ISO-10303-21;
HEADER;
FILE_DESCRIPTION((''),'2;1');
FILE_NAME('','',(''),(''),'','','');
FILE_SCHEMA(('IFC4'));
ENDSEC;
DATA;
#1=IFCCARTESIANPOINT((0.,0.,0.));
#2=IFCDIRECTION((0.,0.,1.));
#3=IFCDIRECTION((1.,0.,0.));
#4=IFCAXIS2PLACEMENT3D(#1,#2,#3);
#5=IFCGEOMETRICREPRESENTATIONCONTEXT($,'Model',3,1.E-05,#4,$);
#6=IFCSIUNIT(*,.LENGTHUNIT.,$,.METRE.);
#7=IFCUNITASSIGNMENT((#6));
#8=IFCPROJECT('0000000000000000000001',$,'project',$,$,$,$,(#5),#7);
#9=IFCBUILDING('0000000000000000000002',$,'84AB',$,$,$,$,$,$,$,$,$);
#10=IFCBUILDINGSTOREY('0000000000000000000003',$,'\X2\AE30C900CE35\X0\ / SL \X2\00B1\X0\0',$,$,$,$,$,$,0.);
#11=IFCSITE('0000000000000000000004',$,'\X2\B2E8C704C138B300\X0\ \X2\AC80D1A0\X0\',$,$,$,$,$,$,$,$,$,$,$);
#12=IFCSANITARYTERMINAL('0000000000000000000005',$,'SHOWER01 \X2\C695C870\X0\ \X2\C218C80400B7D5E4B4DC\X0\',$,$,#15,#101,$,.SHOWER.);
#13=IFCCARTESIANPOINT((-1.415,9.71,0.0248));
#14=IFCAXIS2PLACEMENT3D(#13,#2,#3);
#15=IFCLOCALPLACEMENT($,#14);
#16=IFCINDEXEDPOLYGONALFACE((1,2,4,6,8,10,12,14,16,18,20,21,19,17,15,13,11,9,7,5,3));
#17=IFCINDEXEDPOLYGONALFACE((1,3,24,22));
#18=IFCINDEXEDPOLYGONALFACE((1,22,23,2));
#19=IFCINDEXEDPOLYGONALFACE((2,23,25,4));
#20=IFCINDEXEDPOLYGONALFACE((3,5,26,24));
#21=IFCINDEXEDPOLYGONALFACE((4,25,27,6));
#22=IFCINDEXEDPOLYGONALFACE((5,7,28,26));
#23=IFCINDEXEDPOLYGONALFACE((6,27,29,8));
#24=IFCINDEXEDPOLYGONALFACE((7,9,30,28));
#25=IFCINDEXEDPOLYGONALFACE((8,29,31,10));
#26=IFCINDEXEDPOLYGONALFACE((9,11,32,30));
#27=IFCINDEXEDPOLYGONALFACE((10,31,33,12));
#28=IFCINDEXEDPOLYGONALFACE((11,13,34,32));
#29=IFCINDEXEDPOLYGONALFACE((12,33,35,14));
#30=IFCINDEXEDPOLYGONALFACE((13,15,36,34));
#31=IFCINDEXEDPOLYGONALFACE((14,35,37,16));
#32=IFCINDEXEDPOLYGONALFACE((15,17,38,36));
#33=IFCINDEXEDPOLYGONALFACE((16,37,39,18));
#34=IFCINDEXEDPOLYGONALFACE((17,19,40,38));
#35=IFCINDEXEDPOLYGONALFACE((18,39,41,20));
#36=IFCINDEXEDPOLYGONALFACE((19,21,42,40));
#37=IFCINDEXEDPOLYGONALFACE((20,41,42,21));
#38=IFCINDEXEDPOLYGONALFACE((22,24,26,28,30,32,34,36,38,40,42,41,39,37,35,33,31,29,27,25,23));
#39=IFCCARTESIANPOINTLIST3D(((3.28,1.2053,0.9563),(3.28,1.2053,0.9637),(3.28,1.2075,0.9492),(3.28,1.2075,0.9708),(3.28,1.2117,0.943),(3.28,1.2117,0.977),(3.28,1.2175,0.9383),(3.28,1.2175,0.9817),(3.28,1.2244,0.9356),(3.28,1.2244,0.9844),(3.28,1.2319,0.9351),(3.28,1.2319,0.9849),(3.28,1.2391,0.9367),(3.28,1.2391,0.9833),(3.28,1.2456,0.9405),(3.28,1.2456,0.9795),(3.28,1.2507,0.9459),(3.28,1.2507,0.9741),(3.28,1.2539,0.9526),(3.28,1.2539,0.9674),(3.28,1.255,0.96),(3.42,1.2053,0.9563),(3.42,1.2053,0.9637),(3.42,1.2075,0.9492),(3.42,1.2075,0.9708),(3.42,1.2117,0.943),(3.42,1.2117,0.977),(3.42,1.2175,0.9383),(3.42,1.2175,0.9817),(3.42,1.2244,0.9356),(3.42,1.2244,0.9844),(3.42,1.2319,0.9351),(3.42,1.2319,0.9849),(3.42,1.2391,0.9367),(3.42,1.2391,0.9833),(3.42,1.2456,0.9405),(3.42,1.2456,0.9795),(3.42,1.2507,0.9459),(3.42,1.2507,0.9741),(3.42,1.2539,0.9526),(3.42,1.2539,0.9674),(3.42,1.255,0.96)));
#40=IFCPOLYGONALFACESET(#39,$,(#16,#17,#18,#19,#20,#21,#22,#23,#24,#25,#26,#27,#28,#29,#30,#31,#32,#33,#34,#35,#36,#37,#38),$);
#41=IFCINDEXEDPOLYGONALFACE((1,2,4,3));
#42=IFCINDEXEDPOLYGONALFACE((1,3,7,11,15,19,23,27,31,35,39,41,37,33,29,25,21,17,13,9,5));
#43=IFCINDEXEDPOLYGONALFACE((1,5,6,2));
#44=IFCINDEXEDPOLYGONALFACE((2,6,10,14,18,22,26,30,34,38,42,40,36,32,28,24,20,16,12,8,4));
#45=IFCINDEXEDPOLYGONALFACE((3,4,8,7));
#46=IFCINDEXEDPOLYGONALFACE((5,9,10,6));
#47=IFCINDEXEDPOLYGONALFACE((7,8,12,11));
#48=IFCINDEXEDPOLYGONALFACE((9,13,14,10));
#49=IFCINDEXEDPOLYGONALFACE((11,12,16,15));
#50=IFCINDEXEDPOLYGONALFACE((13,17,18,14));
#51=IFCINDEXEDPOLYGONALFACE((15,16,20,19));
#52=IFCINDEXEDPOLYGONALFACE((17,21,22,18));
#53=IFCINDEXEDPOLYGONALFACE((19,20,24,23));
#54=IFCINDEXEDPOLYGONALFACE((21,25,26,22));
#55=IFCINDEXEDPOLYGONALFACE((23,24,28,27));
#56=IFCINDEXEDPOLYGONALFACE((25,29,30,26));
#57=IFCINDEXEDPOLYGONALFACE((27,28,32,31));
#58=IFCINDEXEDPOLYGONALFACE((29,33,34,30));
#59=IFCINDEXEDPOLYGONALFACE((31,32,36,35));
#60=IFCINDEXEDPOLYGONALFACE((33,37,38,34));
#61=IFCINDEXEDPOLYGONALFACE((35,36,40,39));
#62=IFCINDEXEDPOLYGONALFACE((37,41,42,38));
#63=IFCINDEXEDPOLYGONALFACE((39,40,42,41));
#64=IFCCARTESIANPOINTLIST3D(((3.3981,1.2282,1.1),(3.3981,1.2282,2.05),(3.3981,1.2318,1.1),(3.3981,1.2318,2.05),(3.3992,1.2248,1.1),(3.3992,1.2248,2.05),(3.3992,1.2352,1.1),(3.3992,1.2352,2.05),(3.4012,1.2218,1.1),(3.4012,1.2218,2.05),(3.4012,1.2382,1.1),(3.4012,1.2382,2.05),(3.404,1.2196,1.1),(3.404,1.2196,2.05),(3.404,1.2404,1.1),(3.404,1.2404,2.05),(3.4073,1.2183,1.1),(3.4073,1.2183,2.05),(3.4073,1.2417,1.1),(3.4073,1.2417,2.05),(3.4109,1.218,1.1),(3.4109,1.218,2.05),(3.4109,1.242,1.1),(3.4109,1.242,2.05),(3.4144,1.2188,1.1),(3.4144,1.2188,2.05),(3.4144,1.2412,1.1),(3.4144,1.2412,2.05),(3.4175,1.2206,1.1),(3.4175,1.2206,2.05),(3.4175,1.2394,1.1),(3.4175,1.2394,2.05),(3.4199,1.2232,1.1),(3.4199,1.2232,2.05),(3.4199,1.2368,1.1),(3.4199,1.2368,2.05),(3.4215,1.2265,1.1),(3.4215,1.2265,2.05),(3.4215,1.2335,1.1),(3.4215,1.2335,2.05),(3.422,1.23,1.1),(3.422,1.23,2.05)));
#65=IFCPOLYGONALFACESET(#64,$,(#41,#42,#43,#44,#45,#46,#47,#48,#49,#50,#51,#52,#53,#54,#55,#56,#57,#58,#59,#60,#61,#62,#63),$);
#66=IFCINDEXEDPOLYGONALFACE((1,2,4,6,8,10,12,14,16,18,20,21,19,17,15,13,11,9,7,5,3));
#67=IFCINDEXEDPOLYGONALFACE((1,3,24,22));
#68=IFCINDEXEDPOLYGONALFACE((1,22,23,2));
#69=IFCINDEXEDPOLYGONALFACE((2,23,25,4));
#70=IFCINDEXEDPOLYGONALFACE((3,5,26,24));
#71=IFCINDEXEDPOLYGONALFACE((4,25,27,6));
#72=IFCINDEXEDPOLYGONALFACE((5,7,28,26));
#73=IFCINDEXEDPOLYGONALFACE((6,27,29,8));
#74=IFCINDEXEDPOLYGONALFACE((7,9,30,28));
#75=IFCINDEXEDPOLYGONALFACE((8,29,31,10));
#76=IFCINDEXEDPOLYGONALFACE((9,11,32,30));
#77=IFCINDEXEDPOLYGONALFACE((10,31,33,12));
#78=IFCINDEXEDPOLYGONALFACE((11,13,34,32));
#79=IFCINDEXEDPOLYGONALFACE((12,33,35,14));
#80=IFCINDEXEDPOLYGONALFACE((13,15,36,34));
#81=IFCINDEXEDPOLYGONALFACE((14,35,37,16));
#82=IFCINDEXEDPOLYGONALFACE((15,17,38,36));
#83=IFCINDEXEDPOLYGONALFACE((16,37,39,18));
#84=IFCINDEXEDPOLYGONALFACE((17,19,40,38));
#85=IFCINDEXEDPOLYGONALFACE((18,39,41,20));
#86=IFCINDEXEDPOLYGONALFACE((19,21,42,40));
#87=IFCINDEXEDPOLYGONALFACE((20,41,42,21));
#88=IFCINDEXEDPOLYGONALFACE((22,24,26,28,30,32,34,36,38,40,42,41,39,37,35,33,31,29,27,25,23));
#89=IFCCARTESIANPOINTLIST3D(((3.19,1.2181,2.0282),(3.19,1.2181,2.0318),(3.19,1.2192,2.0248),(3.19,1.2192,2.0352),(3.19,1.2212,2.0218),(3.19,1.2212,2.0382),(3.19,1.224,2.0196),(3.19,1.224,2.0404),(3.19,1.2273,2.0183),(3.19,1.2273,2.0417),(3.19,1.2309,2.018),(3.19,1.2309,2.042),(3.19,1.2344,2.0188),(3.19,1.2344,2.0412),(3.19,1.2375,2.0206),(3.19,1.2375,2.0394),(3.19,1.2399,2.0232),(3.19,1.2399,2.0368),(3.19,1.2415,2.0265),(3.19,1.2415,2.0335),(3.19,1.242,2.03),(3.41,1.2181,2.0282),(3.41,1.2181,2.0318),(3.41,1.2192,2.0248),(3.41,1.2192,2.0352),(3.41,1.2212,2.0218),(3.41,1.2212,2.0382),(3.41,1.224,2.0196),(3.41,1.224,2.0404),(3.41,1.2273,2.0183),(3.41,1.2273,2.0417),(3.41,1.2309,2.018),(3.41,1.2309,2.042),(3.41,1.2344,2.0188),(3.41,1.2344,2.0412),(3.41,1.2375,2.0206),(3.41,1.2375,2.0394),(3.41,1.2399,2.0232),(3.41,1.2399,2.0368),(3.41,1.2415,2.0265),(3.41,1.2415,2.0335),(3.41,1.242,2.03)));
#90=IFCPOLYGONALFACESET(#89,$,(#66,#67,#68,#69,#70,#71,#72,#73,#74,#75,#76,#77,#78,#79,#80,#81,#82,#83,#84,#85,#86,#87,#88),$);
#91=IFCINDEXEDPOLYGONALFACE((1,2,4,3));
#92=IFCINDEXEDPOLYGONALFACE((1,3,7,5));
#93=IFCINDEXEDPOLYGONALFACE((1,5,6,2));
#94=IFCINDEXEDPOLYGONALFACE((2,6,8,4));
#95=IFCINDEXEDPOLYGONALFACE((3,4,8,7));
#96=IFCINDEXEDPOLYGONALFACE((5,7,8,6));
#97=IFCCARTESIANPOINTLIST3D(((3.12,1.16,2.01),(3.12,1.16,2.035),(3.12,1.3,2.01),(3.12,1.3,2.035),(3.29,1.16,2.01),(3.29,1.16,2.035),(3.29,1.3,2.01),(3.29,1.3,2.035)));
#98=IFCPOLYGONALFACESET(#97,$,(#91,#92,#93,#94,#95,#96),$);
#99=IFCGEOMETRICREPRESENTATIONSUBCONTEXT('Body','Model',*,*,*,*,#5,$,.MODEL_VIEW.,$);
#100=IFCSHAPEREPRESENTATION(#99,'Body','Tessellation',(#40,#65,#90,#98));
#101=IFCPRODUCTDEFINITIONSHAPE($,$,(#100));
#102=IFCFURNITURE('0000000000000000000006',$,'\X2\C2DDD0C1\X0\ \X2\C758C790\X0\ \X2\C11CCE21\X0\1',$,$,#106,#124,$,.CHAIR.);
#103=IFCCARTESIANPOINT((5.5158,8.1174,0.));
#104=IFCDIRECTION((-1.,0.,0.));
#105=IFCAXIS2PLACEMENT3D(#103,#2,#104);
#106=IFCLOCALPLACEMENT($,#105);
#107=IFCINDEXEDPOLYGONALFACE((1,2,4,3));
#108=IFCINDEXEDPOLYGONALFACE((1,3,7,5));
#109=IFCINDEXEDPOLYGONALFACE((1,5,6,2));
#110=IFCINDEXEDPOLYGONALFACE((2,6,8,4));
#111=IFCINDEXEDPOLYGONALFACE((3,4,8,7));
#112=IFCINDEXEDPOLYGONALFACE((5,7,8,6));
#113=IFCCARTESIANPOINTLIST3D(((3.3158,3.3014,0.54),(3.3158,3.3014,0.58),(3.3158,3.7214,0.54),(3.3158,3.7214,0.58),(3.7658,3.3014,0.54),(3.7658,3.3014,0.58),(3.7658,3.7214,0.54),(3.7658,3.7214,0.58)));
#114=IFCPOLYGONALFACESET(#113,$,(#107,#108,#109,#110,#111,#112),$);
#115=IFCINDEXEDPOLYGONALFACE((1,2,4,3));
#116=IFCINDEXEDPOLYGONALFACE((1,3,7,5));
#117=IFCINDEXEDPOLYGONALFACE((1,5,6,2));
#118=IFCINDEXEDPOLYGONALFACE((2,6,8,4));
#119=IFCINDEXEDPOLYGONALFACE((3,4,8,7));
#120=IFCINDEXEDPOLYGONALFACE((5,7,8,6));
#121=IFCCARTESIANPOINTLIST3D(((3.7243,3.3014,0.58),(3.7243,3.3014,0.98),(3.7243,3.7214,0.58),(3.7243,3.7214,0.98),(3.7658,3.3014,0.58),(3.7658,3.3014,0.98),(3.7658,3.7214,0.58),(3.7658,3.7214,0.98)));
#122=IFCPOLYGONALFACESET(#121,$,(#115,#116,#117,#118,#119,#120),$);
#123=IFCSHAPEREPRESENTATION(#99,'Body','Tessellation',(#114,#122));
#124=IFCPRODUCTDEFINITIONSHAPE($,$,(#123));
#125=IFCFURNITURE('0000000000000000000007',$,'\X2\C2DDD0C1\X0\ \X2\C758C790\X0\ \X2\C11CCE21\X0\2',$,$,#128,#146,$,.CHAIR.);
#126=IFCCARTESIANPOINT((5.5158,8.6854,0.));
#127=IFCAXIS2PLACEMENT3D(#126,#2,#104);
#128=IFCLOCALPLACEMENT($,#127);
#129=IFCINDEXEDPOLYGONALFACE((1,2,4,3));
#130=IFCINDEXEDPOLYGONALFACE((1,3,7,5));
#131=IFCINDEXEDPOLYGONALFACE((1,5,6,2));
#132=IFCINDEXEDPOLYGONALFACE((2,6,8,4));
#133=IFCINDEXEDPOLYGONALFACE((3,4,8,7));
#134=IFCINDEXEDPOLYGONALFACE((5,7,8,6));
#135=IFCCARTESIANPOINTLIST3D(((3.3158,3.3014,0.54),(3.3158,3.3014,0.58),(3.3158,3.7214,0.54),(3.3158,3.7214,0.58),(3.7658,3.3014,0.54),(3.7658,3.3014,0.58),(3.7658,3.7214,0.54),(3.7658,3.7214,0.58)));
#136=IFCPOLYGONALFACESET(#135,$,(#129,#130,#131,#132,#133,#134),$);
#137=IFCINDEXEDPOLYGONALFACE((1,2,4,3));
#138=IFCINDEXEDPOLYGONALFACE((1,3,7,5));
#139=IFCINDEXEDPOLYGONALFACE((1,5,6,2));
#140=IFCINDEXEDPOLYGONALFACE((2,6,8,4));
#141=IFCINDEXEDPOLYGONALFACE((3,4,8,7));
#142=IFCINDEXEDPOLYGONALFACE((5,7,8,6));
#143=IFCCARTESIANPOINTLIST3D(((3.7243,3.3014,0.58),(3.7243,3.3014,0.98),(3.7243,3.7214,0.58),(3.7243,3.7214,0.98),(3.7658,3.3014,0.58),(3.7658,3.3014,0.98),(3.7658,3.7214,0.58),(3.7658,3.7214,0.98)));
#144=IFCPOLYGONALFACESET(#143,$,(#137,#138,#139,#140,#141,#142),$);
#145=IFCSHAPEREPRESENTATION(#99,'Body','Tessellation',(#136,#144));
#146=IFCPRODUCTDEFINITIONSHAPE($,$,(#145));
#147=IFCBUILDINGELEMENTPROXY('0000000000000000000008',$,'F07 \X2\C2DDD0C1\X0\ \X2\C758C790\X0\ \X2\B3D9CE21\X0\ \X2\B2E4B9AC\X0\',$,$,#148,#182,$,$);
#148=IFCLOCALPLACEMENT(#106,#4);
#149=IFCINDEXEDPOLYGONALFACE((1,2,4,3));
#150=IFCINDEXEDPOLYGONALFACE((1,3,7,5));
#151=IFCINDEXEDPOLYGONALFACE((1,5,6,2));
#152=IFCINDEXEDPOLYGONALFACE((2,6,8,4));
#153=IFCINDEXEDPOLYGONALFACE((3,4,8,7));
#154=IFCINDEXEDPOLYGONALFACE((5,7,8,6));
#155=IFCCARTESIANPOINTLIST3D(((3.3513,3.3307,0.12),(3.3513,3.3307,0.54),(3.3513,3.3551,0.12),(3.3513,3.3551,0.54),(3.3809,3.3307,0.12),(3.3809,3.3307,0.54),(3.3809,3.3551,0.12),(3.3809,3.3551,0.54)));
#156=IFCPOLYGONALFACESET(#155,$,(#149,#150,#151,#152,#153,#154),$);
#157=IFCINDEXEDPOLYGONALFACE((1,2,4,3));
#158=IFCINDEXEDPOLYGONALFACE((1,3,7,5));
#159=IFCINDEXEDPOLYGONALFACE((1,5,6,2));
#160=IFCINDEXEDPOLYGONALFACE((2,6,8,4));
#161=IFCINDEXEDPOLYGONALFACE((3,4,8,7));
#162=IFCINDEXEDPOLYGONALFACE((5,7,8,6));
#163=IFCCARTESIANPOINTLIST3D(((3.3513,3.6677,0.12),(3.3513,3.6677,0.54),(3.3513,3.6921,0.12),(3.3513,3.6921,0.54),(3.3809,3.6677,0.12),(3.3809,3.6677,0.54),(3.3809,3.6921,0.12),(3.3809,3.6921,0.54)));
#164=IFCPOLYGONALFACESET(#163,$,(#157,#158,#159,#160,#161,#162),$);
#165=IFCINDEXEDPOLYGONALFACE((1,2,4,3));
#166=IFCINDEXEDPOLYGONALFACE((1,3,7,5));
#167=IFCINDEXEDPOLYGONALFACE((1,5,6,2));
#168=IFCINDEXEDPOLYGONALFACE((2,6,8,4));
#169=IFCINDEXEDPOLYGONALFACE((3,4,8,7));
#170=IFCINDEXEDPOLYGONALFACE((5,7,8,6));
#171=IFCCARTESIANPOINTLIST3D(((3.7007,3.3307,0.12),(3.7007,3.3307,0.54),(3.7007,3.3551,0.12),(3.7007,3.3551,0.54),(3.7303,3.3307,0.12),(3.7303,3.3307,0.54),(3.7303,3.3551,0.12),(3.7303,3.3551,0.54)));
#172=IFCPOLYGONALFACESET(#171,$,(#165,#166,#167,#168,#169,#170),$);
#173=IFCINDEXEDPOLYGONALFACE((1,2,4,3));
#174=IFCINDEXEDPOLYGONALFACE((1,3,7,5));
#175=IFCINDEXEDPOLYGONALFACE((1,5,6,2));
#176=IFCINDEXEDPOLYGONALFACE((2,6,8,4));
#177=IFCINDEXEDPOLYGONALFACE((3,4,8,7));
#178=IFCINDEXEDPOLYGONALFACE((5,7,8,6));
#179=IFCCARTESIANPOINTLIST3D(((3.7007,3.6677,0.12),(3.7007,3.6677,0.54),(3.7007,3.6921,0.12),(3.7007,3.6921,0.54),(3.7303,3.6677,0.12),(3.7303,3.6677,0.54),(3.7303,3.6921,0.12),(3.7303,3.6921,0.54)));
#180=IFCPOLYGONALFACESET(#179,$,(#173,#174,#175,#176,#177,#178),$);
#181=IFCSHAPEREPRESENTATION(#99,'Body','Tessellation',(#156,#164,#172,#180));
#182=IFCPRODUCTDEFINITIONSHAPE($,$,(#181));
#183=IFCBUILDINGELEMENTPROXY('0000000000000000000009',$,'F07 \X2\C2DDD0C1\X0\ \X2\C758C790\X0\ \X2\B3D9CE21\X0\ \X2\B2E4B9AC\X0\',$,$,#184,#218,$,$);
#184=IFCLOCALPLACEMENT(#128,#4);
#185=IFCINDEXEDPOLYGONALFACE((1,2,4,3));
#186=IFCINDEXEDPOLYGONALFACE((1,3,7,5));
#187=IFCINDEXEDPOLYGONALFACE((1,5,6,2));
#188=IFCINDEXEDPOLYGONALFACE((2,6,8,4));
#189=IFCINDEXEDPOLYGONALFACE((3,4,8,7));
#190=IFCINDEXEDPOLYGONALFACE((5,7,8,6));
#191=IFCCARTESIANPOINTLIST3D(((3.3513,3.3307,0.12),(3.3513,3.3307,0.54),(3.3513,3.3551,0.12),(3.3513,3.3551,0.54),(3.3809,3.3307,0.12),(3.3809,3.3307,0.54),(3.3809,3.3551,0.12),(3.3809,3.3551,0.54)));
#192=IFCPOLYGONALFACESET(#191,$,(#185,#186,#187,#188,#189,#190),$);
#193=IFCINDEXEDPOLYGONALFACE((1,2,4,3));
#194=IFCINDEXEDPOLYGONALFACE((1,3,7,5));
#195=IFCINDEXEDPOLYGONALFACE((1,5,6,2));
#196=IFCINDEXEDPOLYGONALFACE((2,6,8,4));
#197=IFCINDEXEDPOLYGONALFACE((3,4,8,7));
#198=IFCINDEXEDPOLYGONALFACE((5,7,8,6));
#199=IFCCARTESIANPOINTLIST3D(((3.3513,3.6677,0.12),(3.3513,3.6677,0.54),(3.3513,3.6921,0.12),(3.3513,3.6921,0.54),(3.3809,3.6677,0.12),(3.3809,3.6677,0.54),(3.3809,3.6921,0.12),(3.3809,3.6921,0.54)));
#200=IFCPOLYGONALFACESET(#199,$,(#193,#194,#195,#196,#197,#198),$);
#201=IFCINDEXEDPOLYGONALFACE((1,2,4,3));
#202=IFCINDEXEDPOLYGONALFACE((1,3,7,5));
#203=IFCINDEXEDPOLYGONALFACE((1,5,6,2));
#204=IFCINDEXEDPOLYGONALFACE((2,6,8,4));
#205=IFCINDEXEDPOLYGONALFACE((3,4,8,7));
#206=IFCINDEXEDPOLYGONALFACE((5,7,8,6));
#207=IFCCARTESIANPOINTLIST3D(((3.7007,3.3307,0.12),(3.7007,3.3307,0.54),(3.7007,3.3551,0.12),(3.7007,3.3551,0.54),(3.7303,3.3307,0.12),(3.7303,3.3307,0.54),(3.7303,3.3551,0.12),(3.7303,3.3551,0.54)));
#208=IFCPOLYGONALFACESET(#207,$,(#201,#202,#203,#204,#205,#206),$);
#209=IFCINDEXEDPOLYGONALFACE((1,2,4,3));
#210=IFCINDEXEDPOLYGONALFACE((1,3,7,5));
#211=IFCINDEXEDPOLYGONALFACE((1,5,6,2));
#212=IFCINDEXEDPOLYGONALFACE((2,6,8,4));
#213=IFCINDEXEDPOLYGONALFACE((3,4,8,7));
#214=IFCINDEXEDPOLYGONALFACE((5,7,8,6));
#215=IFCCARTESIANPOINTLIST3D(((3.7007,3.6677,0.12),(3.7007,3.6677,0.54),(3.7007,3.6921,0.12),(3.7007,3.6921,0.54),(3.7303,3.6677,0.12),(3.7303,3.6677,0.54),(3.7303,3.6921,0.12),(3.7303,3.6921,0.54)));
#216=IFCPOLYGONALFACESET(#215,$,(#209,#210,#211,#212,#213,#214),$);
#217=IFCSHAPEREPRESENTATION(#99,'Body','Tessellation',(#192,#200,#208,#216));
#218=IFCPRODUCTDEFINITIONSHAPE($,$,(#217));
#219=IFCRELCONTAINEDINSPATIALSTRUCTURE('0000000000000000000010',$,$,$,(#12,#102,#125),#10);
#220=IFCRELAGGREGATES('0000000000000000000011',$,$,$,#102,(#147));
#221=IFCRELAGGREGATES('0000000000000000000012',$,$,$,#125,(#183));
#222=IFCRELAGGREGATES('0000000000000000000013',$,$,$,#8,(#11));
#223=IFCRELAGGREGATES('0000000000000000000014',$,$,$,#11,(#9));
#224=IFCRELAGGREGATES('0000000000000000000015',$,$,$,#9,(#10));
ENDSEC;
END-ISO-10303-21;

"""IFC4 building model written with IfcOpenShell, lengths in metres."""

from ifc_helpers import new_model, si_unit, frame, origin_with_axes, place, context, subcontext, project, spatial, polyline, circle, outline, extrude, element, aggregate, save


model = new_model("IFC4")

# Units and contexts
model_context = context("Model", 3, precision=1e-05, world=origin_with_axes())
body_context = subcontext(model_context, "Body", "Model", "MODEL_VIEW")
ifc_project = project(units=[si_unit("LENGTHUNIT", "METRE")], contexts=[model_context])

# Site, building, storey
site = spatial("IfcSite", under=ifc_project, Name="단위세대 검토")
building = spatial("IfcBuilding", under=site, Name="84AB")
storey = spatial("IfcBuildingStorey", under=building, Name="기준층 / SL ±0", Elevation=0.0)

# Sanitary terminal
sanitary_terminal_1_placement = place(None, frame((-1.415, 9.71, 0.0248), z_axis=(0.0, 0.0, 1.0), x_axis=(1.0, 0.0, 0.0)))
element("IfcSanitaryTerminal", 1, at=sanitary_terminal_1_placement, inside=storey, Name="SHOWER01 욕조 수전·헤드", PredefinedType="SHOWER", context=body_context, shape_type="SweptSolid", body=[
    extrude(circle(Radius=0.025), frame((3.42, 1.23, 0.96), z_axis=(-1.0, 0.0, 0.0), x_axis=(0.0, 1.0, 0.0)), (0.0, 0.0, 1.0), 0.14),
    extrude(circle(Radius=0.012), frame((3.41, 1.23, 1.1), z_axis=(0.0, 0.0, 1.0), x_axis=(1.0, 0.0, 0.0)), (0.0, 0.0, 1.0), 0.95),
    extrude(circle(Radius=0.012), frame((3.41, 1.23, 2.03), z_axis=(-1.0, 0.0, 0.0), x_axis=(0.0, 1.0, 0.0)), (0.0, 0.0, 1.0), 0.22),
    extrude(outline(polyline([(3.29, 1.16), (3.29, 1.3), (3.12, 1.3), (3.12, 1.16), (3.29, 1.16)])), frame((0.0, 0.0, 2.01)), (0.0, 0.0, 1.0), 0.025),
])

# Furniture
furniture_1_placement = place(None, frame((5.5158, 8.1174, 0.0), z_axis=(0.0, 0.0, 1.0), x_axis=(-1.0, 0.0, 0.0)))
furniture_1 = element("IfcFurniture", 2, at=furniture_1_placement, inside=storey, Name="식탁 의자 서측1", PredefinedType="CHAIR", context=body_context, shape_type="SweptSolid", body=[
    extrude(outline(polyline([(3.7658, 3.3014), (3.7658, 3.7214), (3.3158, 3.7214), (3.3158, 3.3014), (3.7658, 3.3014)])), frame((0.0, 0.0, 0.54)), (0.0, 0.0, 1.0), 0.04),
    extrude(outline(polyline([(3.7658, 3.3014), (3.7658, 3.7214), (3.7243, 3.7214), (3.7243, 3.3014), (3.7658, 3.3014)])), frame((0.0, 0.0, 0.58)), (0.0, 0.0, 1.0), 0.4),
])
furniture_2_placement = place(None, frame((5.5158, 8.6854, 0.0), z_axis=(0.0, 0.0, 1.0), x_axis=(-1.0, 0.0, 0.0)))
furniture_2 = element("IfcFurniture", 3, at=furniture_2_placement, inside=storey, Name="식탁 의자 서측2", PredefinedType="CHAIR", context=body_context, shape_type="SweptSolid", body=[
    extrude(outline(polyline([(3.7658, 3.3014), (3.7658, 3.7214), (3.3158, 3.7214), (3.3158, 3.3014), (3.7658, 3.3014)])), frame((0.0, 0.0, 0.54)), (0.0, 0.0, 1.0), 0.04),
    extrude(outline(polyline([(3.7658, 3.3014), (3.7658, 3.7214), (3.7243, 3.7214), (3.7243, 3.3014), (3.7658, 3.3014)])), frame((0.0, 0.0, 0.58)), (0.0, 0.0, 1.0), 0.4),
])

# Building element proxies
proxy_1_placement = place(furniture_1_placement, origin_with_axes())
proxy_1 = element("IfcBuildingElementProxy", 4, at=proxy_1_placement, Name="F07 식탁 의자 동측 다리", context=body_context, shape_type="SweptSolid", body=[
    extrude(outline(polyline([(3.3809, 3.3307), (3.3809, 3.3551), (3.3513, 3.3551), (3.3513, 3.3307), (3.3809, 3.3307)])), frame((0.0, 0.0, 0.12)), (0.0, 0.0, 1.0), 0.42),
    extrude(outline(polyline([(3.3809, 3.6677), (3.3809, 3.6921), (3.3513, 3.6921), (3.3513, 3.6677), (3.3809, 3.6677)])), frame((0.0, 0.0, 0.12)), (0.0, 0.0, 1.0), 0.42),
    extrude(outline(polyline([(3.7303, 3.3307), (3.7303, 3.3551), (3.7007, 3.3551), (3.7007, 3.3307), (3.7303, 3.3307)])), frame((0.0, 0.0, 0.12)), (0.0, 0.0, 1.0), 0.42),
    extrude(outline(polyline([(3.7303, 3.6677), (3.7303, 3.6921), (3.7007, 3.6921), (3.7007, 3.6677), (3.7303, 3.6677)])), frame((0.0, 0.0, 0.12)), (0.0, 0.0, 1.0), 0.42),
])
aggregate(furniture_1, [proxy_1])
proxy_2_placement = place(furniture_2_placement, origin_with_axes())
proxy_2 = element("IfcBuildingElementProxy", 5, at=proxy_2_placement, Name="F07 식탁 의자 동측 다리", context=body_context, shape_type="SweptSolid", body=[
    extrude(outline(polyline([(3.3809, 3.3307), (3.3809, 3.3551), (3.3513, 3.3551), (3.3513, 3.3307), (3.3809, 3.3307)])), frame((0.0, 0.0, 0.12)), (0.0, 0.0, 1.0), 0.42),
    extrude(outline(polyline([(3.3809, 3.6677), (3.3809, 3.6921), (3.3513, 3.6921), (3.3513, 3.6677), (3.3809, 3.6677)])), frame((0.0, 0.0, 0.12)), (0.0, 0.0, 1.0), 0.42),
    extrude(outline(polyline([(3.7303, 3.3307), (3.7303, 3.3551), (3.7007, 3.3551), (3.7007, 3.3307), (3.7303, 3.3307)])), frame((0.0, 0.0, 0.12)), (0.0, 0.0, 1.0), 0.42),
    extrude(outline(polyline([(3.7303, 3.6677), (3.7303, 3.6921), (3.7007, 3.6921), (3.7007, 3.6677), (3.7303, 3.6677)])), frame((0.0, 0.0, 0.12)), (0.0, 0.0, 1.0), 0.42),
])
aggregate(furniture_2, [proxy_2])

save(model, "model.ifc")
